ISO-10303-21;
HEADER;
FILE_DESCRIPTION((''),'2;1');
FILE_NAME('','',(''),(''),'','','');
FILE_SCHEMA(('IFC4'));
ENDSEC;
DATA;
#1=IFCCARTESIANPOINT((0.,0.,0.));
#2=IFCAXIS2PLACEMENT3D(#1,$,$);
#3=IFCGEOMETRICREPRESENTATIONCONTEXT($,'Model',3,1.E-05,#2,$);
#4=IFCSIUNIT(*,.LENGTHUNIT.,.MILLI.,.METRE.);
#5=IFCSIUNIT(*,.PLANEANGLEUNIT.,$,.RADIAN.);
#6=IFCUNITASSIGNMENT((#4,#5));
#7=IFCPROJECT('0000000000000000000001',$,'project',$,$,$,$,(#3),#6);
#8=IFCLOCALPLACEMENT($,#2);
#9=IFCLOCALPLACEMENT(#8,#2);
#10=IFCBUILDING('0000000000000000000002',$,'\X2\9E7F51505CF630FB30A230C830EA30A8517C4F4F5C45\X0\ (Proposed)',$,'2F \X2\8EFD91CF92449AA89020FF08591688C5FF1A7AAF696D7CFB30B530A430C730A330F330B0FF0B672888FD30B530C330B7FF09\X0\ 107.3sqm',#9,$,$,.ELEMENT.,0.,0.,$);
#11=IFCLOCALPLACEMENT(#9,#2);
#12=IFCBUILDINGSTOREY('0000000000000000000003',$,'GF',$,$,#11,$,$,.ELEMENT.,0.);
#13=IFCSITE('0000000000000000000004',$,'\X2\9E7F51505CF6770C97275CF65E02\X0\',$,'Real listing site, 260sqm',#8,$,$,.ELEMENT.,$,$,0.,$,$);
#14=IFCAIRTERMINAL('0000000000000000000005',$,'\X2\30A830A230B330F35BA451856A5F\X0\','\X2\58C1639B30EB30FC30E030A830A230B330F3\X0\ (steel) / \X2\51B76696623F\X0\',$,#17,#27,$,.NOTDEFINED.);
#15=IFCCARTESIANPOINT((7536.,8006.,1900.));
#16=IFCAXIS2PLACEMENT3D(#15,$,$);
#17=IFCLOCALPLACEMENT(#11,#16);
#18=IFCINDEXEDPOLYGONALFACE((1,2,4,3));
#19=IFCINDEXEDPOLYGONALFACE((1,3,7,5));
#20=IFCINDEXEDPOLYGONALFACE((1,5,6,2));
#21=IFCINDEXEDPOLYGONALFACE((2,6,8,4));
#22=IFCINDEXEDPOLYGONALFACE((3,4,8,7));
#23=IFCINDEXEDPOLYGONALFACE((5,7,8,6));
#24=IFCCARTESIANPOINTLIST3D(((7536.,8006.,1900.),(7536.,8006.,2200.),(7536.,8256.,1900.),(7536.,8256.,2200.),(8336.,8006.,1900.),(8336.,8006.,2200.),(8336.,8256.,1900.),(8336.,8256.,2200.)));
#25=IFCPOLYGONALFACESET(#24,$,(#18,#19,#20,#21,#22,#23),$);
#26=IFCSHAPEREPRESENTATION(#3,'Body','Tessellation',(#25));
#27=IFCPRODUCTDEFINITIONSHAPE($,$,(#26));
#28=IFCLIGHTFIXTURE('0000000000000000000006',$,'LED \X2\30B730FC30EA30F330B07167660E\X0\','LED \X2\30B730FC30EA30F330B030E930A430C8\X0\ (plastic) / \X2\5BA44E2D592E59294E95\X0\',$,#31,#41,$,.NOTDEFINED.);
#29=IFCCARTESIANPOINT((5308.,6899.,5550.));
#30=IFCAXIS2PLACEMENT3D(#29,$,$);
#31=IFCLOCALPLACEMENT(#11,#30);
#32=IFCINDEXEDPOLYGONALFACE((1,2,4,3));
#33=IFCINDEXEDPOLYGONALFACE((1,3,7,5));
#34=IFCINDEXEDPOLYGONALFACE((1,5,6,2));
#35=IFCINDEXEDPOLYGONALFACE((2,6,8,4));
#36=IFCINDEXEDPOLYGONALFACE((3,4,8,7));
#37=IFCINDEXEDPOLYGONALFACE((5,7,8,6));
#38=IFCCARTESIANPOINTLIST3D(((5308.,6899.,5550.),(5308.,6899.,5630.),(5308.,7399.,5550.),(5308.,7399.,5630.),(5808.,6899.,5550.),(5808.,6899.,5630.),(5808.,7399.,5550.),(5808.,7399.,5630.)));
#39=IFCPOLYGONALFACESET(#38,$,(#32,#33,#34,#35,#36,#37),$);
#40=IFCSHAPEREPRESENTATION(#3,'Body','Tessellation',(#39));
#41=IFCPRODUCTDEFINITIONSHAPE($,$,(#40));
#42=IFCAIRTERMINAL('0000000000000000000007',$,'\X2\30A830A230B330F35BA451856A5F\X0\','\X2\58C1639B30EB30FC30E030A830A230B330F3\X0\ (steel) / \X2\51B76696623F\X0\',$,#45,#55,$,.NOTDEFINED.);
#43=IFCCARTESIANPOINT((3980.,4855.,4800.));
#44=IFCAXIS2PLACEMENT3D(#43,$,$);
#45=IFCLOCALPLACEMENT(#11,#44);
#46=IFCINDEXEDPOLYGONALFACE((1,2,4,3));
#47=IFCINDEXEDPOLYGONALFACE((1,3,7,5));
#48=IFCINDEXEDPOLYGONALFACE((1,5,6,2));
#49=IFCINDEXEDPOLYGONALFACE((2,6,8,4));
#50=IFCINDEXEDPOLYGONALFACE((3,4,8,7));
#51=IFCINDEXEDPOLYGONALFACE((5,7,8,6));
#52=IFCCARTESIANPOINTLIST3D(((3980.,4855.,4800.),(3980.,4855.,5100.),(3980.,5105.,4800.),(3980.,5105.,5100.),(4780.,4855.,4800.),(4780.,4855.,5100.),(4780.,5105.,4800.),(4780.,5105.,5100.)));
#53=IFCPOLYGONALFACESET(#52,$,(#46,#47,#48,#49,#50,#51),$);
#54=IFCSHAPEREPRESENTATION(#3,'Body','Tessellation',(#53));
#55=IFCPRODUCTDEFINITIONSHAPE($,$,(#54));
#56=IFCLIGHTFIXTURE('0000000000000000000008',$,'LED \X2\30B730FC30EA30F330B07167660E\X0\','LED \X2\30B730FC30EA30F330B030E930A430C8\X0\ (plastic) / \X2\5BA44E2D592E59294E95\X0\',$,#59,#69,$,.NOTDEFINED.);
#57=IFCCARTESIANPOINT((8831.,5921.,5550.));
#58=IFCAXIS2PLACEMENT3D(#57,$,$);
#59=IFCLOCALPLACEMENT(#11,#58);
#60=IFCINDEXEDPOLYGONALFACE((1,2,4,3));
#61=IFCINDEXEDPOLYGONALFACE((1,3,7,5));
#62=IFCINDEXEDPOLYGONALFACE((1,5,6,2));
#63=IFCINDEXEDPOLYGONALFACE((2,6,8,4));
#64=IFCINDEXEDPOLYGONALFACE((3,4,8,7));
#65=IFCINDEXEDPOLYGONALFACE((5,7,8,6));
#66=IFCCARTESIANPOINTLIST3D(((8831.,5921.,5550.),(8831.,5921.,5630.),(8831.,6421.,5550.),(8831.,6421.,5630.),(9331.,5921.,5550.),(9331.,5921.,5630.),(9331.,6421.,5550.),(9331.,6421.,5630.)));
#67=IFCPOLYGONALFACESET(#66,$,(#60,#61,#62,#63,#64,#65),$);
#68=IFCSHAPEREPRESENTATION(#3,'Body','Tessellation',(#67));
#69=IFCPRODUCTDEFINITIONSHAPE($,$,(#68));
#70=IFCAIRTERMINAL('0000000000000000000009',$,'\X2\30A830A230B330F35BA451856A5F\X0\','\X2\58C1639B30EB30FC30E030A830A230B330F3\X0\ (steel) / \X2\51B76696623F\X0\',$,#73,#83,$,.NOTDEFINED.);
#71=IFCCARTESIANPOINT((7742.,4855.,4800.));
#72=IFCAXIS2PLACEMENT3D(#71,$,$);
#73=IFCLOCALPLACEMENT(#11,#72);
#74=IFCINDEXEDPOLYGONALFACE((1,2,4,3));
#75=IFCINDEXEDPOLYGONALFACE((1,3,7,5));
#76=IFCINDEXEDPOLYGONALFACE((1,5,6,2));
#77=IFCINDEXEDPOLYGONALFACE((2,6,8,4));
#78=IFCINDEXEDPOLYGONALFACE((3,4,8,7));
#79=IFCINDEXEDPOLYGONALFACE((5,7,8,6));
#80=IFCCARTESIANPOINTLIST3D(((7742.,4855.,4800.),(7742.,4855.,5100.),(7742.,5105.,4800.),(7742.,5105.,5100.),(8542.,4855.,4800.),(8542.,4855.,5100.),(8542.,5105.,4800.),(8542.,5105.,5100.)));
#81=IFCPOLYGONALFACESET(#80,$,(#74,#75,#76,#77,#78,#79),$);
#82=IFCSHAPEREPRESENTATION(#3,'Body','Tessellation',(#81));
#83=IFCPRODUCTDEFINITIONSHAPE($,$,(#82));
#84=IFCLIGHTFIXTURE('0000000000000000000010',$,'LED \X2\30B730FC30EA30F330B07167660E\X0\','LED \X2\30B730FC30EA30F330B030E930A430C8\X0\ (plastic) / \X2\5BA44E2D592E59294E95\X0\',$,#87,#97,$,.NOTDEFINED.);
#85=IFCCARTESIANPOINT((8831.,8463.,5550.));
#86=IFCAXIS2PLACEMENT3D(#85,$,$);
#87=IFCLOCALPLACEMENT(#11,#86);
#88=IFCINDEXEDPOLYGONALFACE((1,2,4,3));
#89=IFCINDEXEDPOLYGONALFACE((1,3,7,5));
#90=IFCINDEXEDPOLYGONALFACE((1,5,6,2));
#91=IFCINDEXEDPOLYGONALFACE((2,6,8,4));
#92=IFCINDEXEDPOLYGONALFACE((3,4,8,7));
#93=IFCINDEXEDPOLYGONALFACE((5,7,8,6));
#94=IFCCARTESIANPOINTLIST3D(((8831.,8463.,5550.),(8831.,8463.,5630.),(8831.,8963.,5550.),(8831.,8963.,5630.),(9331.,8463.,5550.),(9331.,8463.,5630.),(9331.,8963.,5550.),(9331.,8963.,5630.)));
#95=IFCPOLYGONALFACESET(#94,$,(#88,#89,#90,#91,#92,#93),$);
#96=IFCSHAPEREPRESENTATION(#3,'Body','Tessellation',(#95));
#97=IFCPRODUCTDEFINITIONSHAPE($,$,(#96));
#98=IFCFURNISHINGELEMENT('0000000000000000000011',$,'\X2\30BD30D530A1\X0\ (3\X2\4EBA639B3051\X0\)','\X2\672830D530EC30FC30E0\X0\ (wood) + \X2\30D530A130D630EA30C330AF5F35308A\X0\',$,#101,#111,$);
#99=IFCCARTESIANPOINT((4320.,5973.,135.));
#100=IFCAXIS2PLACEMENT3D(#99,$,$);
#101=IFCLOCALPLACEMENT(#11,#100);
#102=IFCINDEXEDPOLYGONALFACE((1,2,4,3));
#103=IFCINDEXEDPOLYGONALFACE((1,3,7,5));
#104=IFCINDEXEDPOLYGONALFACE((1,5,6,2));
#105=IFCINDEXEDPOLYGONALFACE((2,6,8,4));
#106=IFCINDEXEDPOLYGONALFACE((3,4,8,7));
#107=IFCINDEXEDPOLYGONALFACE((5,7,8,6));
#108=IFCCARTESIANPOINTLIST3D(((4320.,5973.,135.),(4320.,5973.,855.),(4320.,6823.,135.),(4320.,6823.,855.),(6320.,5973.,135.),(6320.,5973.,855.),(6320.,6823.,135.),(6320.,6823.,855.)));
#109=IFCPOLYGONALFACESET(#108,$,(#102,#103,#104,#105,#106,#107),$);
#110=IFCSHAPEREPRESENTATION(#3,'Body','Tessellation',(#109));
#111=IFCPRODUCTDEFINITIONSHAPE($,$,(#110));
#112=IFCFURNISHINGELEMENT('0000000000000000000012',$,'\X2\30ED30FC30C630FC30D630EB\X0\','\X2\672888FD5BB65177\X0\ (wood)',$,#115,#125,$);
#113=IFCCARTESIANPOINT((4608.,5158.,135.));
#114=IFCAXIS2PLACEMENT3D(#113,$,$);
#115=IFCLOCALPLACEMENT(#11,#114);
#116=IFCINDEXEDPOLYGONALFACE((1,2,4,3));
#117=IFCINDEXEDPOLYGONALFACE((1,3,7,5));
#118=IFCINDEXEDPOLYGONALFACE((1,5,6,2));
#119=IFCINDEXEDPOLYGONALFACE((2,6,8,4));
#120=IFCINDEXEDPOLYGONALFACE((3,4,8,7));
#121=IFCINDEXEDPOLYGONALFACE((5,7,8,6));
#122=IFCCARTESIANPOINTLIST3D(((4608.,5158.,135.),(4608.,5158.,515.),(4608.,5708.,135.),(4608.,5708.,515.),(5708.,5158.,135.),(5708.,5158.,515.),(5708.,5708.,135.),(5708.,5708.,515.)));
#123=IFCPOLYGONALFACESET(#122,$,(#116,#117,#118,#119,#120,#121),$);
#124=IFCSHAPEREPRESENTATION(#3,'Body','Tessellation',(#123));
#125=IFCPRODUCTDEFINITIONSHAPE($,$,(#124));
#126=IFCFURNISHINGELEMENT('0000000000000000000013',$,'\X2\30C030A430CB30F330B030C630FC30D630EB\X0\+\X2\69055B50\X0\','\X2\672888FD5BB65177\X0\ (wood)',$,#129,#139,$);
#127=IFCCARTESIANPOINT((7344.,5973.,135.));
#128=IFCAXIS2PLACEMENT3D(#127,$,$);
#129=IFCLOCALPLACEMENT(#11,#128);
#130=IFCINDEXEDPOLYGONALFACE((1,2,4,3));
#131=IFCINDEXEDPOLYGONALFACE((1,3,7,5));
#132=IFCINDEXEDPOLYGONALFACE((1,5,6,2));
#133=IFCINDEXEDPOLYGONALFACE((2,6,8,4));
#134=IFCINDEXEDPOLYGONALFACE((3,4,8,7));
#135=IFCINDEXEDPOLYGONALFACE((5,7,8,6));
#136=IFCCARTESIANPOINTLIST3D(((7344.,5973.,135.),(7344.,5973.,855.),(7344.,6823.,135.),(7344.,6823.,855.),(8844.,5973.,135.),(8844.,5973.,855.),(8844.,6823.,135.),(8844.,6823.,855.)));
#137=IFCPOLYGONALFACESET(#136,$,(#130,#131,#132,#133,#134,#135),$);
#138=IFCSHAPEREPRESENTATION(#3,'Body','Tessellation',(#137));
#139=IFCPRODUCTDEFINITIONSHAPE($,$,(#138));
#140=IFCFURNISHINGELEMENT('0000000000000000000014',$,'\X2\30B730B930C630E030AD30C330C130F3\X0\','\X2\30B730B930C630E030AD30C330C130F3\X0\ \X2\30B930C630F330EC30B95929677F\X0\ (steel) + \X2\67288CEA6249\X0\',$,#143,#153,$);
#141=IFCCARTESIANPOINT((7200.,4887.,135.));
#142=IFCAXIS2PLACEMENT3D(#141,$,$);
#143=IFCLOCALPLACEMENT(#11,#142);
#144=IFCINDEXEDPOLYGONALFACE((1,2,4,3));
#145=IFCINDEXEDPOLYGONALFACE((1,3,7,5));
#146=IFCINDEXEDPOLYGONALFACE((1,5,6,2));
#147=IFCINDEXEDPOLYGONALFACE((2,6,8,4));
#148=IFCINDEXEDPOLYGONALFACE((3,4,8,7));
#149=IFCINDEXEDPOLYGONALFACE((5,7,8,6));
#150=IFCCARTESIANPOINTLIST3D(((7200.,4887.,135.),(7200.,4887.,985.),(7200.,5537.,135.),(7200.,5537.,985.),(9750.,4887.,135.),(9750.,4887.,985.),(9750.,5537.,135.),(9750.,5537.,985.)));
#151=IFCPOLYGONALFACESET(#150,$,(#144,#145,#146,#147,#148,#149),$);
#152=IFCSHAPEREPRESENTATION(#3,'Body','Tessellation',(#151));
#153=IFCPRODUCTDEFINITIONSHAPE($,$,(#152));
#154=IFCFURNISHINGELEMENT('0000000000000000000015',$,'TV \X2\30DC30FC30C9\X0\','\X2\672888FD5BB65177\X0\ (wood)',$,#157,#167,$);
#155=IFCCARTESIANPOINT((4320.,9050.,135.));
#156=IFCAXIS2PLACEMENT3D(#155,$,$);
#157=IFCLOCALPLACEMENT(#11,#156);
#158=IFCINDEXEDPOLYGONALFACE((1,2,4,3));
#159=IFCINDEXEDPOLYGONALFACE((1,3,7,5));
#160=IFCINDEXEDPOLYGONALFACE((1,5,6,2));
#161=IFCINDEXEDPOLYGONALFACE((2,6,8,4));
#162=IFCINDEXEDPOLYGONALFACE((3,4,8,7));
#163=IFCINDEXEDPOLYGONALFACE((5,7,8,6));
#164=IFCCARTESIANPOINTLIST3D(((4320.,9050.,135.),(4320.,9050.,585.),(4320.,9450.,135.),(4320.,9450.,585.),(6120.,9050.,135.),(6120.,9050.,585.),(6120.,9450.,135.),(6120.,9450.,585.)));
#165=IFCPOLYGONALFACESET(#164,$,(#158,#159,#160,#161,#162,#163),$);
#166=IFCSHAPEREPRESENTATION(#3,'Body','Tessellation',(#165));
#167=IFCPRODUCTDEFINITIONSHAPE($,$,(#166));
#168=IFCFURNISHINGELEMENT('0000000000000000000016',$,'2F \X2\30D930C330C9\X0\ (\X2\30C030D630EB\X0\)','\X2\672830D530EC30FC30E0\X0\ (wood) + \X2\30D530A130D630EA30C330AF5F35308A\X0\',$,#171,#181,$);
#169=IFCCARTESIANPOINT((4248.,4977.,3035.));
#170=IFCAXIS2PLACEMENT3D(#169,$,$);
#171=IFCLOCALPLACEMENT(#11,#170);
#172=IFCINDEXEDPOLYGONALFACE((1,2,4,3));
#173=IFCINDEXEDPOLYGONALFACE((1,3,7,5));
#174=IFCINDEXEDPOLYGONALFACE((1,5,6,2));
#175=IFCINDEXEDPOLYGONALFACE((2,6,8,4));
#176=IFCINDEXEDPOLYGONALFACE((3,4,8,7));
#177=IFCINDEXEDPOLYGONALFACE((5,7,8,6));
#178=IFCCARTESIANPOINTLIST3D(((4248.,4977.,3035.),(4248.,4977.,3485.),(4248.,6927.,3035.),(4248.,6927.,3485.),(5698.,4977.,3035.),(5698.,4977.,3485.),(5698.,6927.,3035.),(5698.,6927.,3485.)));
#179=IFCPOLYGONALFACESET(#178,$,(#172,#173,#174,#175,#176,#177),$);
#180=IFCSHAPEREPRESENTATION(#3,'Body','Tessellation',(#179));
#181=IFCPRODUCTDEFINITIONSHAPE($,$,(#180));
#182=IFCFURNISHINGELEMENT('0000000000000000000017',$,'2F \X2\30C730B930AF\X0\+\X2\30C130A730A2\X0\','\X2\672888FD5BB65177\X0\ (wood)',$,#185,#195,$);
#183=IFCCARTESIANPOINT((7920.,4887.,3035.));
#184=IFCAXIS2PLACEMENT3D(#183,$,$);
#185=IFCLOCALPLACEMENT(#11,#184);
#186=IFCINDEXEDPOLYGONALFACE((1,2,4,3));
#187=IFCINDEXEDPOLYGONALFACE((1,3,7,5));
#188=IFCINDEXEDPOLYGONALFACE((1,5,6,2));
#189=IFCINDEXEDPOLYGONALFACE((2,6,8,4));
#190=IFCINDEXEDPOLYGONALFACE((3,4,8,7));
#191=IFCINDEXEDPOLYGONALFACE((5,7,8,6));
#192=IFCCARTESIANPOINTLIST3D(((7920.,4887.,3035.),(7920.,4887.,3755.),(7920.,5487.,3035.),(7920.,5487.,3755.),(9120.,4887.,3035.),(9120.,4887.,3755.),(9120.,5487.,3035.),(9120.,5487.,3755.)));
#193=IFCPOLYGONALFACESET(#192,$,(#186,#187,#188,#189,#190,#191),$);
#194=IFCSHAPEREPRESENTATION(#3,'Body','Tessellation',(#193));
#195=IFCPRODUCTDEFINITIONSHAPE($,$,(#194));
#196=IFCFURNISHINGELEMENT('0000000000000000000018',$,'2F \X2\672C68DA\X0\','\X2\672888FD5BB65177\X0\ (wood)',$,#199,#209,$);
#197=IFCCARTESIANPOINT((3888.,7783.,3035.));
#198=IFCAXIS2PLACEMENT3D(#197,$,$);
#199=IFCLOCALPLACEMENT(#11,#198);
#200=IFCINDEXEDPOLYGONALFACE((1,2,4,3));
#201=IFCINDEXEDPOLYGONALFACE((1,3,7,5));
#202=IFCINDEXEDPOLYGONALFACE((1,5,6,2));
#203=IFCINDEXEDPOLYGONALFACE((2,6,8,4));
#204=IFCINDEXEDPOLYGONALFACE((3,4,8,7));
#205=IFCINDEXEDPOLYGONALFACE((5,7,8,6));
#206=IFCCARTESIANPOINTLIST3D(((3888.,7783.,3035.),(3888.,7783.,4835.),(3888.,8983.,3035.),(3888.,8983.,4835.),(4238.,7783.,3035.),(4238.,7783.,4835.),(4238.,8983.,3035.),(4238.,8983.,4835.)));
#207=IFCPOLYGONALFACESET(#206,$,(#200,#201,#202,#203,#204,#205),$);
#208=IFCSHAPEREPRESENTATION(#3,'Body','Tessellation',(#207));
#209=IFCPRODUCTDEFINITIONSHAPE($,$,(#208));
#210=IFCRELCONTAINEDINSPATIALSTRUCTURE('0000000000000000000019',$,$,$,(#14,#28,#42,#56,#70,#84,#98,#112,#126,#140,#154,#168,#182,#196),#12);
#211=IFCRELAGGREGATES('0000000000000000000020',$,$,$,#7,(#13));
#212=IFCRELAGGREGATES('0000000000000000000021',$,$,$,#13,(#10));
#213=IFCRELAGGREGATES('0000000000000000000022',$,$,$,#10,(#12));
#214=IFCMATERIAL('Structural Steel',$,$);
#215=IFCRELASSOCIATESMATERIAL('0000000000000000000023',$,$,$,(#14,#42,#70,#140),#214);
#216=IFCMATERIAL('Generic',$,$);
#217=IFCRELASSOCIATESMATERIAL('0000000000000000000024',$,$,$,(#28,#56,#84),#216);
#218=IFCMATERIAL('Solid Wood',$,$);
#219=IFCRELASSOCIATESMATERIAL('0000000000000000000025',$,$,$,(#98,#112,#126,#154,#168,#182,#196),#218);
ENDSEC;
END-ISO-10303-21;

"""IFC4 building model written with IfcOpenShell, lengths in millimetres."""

from ifc_helpers import new_model, si_unit, frame, frame_2d, origin, place, context, project, spatial, rectangle, extrude, material, element, save


model = new_model("IFC4")

# Units and contexts
model_context = context("Model", 3, precision=1e-05, world=origin())
ifc_project = project(units=[si_unit("LENGTHUNIT", "METRE", prefix="MILLI"), si_unit("PLANEANGLEUNIT", "RADIAN")], contexts=[model_context])

# Site, building, storey
site_placement = place(None, origin())
site = spatial("IfcSite", under=ifc_project, at=site_placement, Name="鹿児島県霧島市", ObjectType="Real listing site, 260sqm", CompositionType="ELEMENT", RefElevation=0.0)
building_placement = place(site_placement, origin())
building = spatial("IfcBuilding", under=site, at=building_placement, Name="鹿児島・アトリエ兼住居 (Proposed)", ObjectType="2F 軽量鉄骨造（外装：窯業系サイディング＋木製サッシ） 107.3sqm", CompositionType="ELEMENT", ElevationOfRefHeight=0.0, ElevationOfTerrain=0.0)
storey_placement = place(building_placement, origin())
storey = spatial("IfcBuildingStorey", under=building, at=storey_placement, Name="GF", CompositionType="ELEMENT", Elevation=0.0)

# Shared definitions
ifc_material_1 = material(Name="Solid Wood")

# Shared definitions
ifc_material_2 = material(Name="Structural Steel")

# Shared definitions
ifc_material_3 = material(Name="Generic")

# Air terminal
air_terminal_1_placement = place(storey_placement, frame((7536.0, 8006.0, 1900.0)))
element("IfcAirTerminal", 1, at=air_terminal_1_placement, inside=storey, material=ifc_material_2, Name="エアコン室内機", Description="壁掛ルームエアコン (steel) / 冷暖房", PredefinedType="NOTDEFINED", context=model_context, shape_type="SweptSolid", body=[
    extrude(rectangle(XDim=800.0, YDim=250.0, at=frame_2d((400.0, 125.0))), frame((7536.0, 8006.0, 1900.0)), (0.0, 0.0, 1.0), 300.0),
])

# Light fixture
light_fixture_1_placement = place(storey_placement, frame((5308.0, 6899.0, 5550.0)))
element("IfcLightFixture", 2, at=light_fixture_1_placement, inside=storey, material=ifc_material_3, Name="LED シーリング照明", Description="LED シーリングライト (plastic) / 室中央天井", PredefinedType="NOTDEFINED", context=model_context, shape_type="SweptSolid", body=[
    extrude(rectangle(XDim=500.0, YDim=500.0, at=frame_2d((250.0, 250.0))), frame((5308.0, 6899.0, 5550.0)), (0.0, 0.0, 1.0), 80.0),
])

# Air terminal
air_terminal_2_placement = place(storey_placement, frame((3980.0, 4855.0, 4800.0)))
element("IfcAirTerminal", 3, at=air_terminal_2_placement, inside=storey, material=ifc_material_2, Name="エアコン室内機", Description="壁掛ルームエアコン (steel) / 冷暖房", PredefinedType="NOTDEFINED", context=model_context, shape_type="SweptSolid", body=[
    extrude(rectangle(XDim=800.0, YDim=250.0, at=frame_2d((400.0, 125.0))), frame((3980.0, 4855.0, 4800.0)), (0.0, 0.0, 1.0), 300.0),
])

# Light fixture
light_fixture_2_placement = place(storey_placement, frame((8831.0, 5921.0, 5550.0)))
element("IfcLightFixture", 4, at=light_fixture_2_placement, inside=storey, material=ifc_material_3, Name="LED シーリング照明", Description="LED シーリングライト (plastic) / 室中央天井", PredefinedType="NOTDEFINED", context=model_context, shape_type="SweptSolid", body=[
    extrude(rectangle(XDim=500.0, YDim=500.0, at=frame_2d((250.0, 250.0))), frame((8831.0, 5921.0, 5550.0)), (0.0, 0.0, 1.0), 80.0),
])

# Air terminal
air_terminal_3_placement = place(storey_placement, frame((7742.0, 4855.0, 4800.0)))
element("IfcAirTerminal", 5, at=air_terminal_3_placement, inside=storey, material=ifc_material_2, Name="エアコン室内機", Description="壁掛ルームエアコン (steel) / 冷暖房", PredefinedType="NOTDEFINED", context=model_context, shape_type="SweptSolid", body=[
    extrude(rectangle(XDim=800.0, YDim=250.0, at=frame_2d((400.0, 125.0))), frame((7742.0, 4855.0, 4800.0)), (0.0, 0.0, 1.0), 300.0),
])

# Light fixture
light_fixture_3_placement = place(storey_placement, frame((8831.0, 8463.0, 5550.0)))
element("IfcLightFixture", 6, at=light_fixture_3_placement, inside=storey, material=ifc_material_3, Name="LED シーリング照明", Description="LED シーリングライト (plastic) / 室中央天井", PredefinedType="NOTDEFINED", context=model_context, shape_type="SweptSolid", body=[
    extrude(rectangle(XDim=500.0, YDim=500.0, at=frame_2d((250.0, 250.0))), frame((8831.0, 8463.0, 5550.0)), (0.0, 0.0, 1.0), 80.0),
])

# Furnishing elements
furnishing_1_placement = place(storey_placement, frame((4320.0, 5973.0, 135.0)))
element("IfcFurnishingElement", 7, at=furnishing_1_placement, inside=storey, material=ifc_material_1, Name="ソファ (3人掛け)", Description="木フレーム (wood) + ファブリック張り", context=model_context, shape_type="SweptSolid", body=[
    extrude(rectangle(XDim=2000.0, YDim=850.0, at=frame_2d((1000.0, 425.0))), frame((4320.0, 5973.0, 135.0)), (0.0, 0.0, 1.0), 720.0),
])
furnishing_2_placement = place(storey_placement, frame((4608.0, 5158.0, 135.0)))
element("IfcFurnishingElement", 8, at=furnishing_2_placement, inside=storey, material=ifc_material_1, Name="ローテーブル", Description="木製家具 (wood)", context=model_context, shape_type="SweptSolid", body=[
    extrude(rectangle(XDim=1100.0, YDim=550.0, at=frame_2d((550.0, 275.0))), frame((4608.0, 5158.0, 135.0)), (0.0, 0.0, 1.0), 380.0),
])
furnishing_3_placement = place(storey_placement, frame((7344.0, 5973.0, 135.0)))
element("IfcFurnishingElement", 9, at=furnishing_3_placement, inside=storey, material=ifc_material_1, Name="ダイニングテーブル+椅子", Description="木製家具 (wood)", context=model_context, shape_type="SweptSolid", body=[
    extrude(rectangle(XDim=1500.0, YDim=850.0, at=frame_2d((750.0, 425.0))), frame((7344.0, 5973.0, 135.0)), (0.0, 0.0, 1.0), 720.0),
])
furnishing_4_placement = place(storey_placement, frame((7200.0, 4887.0, 135.0)))
element("IfcFurnishingElement", 10, at=furnishing_4_placement, inside=storey, material=ifc_material_2, Name="システムキッチン", Description="システムキッチン ステンレス天板 (steel) + 木質扉", context=model_context, shape_type="SweptSolid", body=[
    extrude(rectangle(XDim=2550.0, YDim=650.0, at=frame_2d((1275.0, 325.0))), frame((7200.0, 4887.0, 135.0)), (0.0, 0.0, 1.0), 850.0),
])
furnishing_5_placement = place(storey_placement, frame((4320.0, 9050.0, 135.0)))
element("IfcFurnishingElement", 11, at=furnishing_5_placement, inside=storey, material=ifc_material_1, Name="TV ボード", Description="木製家具 (wood)", context=model_context, shape_type="SweptSolid", body=[
    extrude(rectangle(XDim=1800.0, YDim=400.0, at=frame_2d((900.0, 200.0))), frame((4320.0, 9050.0, 135.0)), (0.0, 0.0, 1.0), 450.0),
])
furnishing_6_placement = place(storey_placement, frame((4248.0, 4977.0, 3035.0)))
element("IfcFurnishingElement", 12, at=furnishing_6_placement, inside=storey, material=ifc_material_1, Name="2F ベッド (ダブル)", Description="木フレーム (wood) + ファブリック張り", context=model_context, shape_type="SweptSolid", body=[
    extrude(rectangle(XDim=1450.0, YDim=1950.0, at=frame_2d((725.0, 975.0))), frame((4248.0, 4977.0, 3035.0)), (0.0, 0.0, 1.0), 450.0),
])
furnishing_7_placement = place(storey_placement, frame((7920.0, 4887.0, 3035.0)))
element("IfcFurnishingElement", 13, at=furnishing_7_placement, inside=storey, material=ifc_material_1, Name="2F デスク+チェア", Description="木製家具 (wood)", context=model_context, shape_type="SweptSolid", body=[
    extrude(rectangle(XDim=1200.0, YDim=600.0, at=frame_2d((600.0, 300.0))), frame((7920.0, 4887.0, 3035.0)), (0.0, 0.0, 1.0), 720.0),
])
furnishing_8_placement = place(storey_placement, frame((3888.0, 7783.0, 3035.0)))
element("IfcFurnishingElement", 14, at=furnishing_8_placement, inside=storey, material=ifc_material_1, Name="2F 本棚", Description="木製家具 (wood)", context=model_context, shape_type="SweptSolid", body=[
    extrude(rectangle(XDim=350.0, YDim=1200.0, at=frame_2d((175.0, 600.0))), frame((3888.0, 7783.0, 3035.0)), (0.0, 0.0, 1.0), 1800.0),
])

save(model, "model.ifc")
